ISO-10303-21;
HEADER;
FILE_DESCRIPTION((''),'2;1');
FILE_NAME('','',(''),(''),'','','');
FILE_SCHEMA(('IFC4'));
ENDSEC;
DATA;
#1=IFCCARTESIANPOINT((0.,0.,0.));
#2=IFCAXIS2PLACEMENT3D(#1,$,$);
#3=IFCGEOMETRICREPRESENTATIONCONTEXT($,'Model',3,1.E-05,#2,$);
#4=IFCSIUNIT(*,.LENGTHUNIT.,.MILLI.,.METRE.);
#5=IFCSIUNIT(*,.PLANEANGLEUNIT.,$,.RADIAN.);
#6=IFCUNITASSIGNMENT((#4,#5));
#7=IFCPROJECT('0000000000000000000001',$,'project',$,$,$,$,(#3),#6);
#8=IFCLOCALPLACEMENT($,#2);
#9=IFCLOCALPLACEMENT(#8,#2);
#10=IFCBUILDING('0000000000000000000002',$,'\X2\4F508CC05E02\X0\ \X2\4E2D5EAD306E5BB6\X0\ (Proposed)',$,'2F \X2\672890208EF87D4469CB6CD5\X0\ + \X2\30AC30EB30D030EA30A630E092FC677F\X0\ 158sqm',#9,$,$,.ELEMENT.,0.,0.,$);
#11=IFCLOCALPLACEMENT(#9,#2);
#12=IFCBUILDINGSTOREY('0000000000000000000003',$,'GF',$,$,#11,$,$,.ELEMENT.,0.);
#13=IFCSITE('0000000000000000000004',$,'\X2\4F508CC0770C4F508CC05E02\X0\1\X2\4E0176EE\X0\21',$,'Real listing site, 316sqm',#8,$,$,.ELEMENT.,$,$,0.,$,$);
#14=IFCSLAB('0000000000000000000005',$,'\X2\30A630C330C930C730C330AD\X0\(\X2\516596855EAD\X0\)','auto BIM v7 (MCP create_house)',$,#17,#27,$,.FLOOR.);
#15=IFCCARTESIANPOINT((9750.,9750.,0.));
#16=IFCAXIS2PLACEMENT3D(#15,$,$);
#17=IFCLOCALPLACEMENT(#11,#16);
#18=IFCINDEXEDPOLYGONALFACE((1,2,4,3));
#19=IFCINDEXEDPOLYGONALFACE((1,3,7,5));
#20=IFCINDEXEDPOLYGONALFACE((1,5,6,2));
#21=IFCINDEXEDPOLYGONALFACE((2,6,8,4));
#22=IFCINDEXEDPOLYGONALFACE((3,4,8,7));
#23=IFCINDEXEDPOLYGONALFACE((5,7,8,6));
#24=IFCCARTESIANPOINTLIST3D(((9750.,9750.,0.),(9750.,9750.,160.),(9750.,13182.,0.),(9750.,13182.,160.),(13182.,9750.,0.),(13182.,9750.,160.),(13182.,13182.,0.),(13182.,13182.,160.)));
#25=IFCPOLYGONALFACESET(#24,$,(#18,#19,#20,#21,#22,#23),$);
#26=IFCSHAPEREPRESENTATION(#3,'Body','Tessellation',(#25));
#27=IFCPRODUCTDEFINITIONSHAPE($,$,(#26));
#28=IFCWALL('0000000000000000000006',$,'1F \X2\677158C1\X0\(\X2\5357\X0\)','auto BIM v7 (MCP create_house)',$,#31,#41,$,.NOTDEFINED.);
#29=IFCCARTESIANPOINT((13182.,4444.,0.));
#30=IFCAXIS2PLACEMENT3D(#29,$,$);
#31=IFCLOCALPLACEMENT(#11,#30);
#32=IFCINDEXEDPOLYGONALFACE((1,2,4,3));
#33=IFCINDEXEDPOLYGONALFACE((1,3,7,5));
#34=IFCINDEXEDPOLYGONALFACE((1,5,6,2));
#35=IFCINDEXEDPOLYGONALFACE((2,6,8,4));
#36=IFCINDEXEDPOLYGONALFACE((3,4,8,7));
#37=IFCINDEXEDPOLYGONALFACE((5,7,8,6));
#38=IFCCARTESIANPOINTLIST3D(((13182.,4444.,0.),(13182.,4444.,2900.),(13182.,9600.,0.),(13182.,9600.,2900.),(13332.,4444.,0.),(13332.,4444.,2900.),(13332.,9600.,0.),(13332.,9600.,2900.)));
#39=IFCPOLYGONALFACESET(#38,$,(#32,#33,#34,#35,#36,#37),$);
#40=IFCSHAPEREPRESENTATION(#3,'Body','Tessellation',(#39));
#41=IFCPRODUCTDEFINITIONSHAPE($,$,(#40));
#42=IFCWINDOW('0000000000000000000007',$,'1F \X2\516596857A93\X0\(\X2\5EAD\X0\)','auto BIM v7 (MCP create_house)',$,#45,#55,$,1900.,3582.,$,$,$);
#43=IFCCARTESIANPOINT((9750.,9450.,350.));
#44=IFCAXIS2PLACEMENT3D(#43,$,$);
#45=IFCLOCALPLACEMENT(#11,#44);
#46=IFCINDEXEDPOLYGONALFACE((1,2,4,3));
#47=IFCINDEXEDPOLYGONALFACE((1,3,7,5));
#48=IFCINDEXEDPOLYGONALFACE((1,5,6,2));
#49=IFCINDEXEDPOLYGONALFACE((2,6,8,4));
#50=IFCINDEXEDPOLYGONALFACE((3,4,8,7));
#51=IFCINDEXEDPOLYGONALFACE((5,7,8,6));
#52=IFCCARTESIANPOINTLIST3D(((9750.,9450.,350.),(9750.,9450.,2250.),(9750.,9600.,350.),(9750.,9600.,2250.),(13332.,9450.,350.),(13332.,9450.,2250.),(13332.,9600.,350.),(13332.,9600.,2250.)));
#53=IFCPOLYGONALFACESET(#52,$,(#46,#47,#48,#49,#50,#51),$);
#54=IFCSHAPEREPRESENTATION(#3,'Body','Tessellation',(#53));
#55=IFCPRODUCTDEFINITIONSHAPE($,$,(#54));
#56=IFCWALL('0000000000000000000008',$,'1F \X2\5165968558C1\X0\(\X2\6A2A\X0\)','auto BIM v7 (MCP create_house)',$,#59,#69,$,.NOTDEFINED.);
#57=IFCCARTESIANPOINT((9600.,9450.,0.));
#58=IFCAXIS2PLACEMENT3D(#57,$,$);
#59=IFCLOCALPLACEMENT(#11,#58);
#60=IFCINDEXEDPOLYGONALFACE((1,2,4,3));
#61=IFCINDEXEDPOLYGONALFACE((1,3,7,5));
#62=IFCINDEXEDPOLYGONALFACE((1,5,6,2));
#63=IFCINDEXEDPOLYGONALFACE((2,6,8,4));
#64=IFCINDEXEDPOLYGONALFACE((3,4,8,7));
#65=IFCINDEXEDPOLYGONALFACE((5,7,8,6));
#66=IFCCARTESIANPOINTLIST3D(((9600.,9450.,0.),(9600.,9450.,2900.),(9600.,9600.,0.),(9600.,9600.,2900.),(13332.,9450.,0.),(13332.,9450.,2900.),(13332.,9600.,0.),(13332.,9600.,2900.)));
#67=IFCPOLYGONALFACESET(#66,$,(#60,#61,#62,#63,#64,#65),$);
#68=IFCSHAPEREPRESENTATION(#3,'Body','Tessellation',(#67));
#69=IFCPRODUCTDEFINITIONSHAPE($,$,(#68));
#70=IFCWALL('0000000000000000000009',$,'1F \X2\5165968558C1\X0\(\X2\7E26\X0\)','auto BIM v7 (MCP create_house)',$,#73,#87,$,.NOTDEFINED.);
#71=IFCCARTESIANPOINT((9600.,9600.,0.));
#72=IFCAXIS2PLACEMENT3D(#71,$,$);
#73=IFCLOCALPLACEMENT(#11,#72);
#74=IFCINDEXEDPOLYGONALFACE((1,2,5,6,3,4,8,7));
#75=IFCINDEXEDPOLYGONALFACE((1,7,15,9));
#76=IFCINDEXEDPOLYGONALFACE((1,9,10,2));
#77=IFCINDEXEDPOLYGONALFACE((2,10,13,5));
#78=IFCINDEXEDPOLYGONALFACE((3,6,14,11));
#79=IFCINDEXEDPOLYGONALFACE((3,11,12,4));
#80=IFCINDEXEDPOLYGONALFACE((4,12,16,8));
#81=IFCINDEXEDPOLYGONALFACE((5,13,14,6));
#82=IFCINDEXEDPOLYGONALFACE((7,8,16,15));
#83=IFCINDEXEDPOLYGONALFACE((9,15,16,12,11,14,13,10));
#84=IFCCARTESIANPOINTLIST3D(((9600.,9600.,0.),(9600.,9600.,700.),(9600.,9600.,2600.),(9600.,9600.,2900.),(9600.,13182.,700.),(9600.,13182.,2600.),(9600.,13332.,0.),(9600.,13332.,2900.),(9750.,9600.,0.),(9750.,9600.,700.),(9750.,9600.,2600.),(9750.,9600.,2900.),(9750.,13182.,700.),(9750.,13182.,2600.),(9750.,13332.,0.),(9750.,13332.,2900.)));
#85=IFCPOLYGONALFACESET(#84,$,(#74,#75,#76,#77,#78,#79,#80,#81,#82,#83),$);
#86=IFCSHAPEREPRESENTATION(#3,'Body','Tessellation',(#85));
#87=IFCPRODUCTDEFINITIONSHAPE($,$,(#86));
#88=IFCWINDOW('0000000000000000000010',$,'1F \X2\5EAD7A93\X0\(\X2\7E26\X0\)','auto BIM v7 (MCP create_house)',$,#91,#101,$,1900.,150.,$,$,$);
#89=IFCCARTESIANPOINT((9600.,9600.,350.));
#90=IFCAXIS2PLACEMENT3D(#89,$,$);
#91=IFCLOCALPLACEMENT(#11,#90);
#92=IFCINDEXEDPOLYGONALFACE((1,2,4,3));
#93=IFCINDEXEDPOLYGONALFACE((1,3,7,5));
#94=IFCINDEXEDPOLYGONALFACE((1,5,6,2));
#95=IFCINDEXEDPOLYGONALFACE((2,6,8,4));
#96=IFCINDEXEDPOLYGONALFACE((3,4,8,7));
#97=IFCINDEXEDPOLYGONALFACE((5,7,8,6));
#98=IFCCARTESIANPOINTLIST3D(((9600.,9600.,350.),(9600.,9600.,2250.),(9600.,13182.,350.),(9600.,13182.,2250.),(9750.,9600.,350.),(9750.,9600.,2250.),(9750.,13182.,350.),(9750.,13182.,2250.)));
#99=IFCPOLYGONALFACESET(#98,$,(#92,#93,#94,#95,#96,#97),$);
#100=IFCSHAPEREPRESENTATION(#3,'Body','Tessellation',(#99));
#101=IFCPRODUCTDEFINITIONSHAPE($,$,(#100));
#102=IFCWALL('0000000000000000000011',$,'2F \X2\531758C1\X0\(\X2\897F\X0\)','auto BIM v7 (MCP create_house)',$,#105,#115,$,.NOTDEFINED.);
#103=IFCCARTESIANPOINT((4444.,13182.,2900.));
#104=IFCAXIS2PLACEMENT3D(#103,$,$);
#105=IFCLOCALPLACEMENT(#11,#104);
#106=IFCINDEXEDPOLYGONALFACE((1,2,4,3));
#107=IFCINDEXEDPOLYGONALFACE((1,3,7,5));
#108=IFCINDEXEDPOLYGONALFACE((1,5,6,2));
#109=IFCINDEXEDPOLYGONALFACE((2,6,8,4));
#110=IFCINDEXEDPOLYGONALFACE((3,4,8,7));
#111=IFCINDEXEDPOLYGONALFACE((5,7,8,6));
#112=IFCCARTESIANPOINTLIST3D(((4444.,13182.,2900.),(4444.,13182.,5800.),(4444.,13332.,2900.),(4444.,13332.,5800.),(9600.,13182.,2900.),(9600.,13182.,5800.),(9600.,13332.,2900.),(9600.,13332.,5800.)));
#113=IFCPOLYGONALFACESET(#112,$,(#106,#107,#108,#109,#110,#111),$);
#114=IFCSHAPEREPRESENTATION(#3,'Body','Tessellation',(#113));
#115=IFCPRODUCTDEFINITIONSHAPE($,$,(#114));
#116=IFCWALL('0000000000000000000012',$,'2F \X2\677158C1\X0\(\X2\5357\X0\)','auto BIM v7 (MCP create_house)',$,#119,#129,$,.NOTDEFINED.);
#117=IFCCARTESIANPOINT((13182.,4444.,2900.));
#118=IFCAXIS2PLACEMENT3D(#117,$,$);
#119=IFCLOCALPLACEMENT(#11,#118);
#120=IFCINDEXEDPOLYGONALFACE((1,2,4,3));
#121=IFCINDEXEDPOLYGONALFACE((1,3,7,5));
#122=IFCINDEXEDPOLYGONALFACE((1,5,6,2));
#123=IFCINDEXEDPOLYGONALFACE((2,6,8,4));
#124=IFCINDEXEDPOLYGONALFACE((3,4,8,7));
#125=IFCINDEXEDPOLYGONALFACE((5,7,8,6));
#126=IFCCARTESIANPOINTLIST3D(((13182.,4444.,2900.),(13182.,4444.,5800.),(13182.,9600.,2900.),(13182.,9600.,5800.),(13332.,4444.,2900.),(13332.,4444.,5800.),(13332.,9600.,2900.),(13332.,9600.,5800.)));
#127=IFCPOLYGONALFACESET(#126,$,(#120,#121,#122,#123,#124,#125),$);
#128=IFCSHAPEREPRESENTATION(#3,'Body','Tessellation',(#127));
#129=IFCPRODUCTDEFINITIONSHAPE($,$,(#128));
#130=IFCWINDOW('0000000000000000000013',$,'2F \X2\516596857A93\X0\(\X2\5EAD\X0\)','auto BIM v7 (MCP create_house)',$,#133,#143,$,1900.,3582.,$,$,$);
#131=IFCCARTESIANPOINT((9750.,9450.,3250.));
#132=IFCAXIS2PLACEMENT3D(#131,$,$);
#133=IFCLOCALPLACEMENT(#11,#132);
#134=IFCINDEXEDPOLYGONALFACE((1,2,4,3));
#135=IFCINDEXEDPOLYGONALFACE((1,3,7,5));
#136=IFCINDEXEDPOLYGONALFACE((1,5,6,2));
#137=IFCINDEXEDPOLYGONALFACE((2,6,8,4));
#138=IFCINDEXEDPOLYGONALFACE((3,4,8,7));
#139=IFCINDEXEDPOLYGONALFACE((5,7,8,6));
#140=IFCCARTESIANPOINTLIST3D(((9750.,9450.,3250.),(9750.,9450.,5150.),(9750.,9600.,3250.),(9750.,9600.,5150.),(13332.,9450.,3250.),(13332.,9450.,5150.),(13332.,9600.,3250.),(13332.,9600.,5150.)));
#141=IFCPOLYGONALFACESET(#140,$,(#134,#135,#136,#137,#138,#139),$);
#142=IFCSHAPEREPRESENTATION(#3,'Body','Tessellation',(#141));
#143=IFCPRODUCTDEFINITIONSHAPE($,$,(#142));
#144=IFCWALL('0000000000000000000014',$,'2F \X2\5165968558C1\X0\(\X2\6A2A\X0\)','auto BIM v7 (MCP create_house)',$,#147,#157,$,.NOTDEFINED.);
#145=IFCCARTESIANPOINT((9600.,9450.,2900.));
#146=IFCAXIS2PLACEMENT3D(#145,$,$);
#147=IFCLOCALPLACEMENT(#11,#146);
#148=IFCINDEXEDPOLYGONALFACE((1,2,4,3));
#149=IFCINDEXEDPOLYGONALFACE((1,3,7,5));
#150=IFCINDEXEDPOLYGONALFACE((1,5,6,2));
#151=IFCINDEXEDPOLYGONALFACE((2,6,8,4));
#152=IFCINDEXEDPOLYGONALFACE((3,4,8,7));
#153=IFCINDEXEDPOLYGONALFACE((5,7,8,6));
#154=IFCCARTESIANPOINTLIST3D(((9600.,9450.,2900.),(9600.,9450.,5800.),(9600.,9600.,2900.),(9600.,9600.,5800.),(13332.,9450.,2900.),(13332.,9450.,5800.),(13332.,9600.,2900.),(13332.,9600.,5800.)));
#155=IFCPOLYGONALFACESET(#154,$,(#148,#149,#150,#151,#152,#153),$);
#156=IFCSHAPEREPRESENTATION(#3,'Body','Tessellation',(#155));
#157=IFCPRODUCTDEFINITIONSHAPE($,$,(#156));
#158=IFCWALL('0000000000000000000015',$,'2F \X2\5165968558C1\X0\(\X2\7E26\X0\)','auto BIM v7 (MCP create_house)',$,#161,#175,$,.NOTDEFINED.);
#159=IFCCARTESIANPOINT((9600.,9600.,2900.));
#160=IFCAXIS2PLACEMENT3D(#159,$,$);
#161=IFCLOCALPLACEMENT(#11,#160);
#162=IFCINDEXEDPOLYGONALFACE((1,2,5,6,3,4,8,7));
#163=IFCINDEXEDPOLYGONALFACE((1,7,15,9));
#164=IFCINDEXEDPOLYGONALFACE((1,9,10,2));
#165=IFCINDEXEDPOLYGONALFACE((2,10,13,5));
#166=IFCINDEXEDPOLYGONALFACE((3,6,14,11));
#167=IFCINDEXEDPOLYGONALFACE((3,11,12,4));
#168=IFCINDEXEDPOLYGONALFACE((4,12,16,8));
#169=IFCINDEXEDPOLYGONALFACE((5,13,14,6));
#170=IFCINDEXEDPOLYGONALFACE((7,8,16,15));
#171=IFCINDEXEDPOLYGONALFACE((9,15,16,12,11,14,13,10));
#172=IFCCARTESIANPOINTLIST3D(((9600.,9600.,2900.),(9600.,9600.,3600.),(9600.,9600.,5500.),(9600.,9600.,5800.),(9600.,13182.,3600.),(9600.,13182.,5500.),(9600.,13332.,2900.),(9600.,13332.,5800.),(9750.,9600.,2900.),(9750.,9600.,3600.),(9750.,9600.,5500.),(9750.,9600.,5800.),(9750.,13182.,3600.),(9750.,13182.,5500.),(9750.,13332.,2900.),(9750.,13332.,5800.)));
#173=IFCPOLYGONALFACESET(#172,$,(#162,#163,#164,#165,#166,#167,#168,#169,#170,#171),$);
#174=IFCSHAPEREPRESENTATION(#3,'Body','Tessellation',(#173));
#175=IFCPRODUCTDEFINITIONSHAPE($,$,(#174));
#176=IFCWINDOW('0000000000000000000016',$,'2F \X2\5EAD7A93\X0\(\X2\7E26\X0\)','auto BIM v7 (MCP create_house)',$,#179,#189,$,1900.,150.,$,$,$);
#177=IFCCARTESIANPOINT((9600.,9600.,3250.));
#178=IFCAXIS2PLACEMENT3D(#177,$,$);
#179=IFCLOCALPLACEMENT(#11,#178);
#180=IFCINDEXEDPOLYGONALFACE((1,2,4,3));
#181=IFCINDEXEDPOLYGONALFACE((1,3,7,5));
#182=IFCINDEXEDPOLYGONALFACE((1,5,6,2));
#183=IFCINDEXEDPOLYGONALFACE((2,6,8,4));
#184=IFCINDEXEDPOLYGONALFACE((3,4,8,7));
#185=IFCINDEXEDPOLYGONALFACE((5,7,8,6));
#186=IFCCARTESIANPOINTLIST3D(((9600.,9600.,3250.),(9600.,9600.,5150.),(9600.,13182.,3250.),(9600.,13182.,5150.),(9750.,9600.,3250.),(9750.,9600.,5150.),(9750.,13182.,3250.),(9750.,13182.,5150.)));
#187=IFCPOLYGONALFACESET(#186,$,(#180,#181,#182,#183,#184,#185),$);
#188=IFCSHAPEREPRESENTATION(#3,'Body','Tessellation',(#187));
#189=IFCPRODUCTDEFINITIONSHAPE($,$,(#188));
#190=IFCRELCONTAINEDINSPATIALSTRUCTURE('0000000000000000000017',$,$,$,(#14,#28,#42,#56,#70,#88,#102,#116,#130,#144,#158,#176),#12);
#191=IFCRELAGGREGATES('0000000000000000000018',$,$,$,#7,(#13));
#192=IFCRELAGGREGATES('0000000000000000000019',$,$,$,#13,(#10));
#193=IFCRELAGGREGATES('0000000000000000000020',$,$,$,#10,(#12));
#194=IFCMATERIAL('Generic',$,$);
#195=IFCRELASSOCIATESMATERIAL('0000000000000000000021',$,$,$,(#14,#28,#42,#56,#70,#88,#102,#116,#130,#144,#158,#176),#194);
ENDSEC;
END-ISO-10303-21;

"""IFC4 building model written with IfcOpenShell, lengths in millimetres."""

from ifc_helpers import new_model, si_unit, frame, frame_2d, origin, place, context, project, spatial, rectangle, extrude, material, element, fill, save


model = new_model("IFC4")

# Units and contexts
model_context = context("Model", 3, precision=1e-05, world=origin())
ifc_project = project(units=[si_unit("LENGTHUNIT", "METRE", prefix="MILLI"), si_unit("PLANEANGLEUNIT", "RADIAN")], contexts=[model_context])

# Site, building, storey
site_placement = place(None, origin())
site = spatial("IfcSite", under=ifc_project, at=site_placement, Name="佐賀県佐賀市1丁目21", ObjectType="Real listing site, 316sqm", CompositionType="ELEMENT", RefElevation=0.0)
building_placement = place(site_placement, origin())
building = spatial("IfcBuilding", under=site, at=building_placement, Name="佐賀市 中庭の家 (Proposed)", ObjectType="2F 木造軸組構法 + ガルバリウム鋼板 158sqm", CompositionType="ELEMENT", ElevationOfRefHeight=0.0, ElevationOfTerrain=0.0)
storey_placement = place(building_placement, origin())
storey = spatial("IfcBuildingStorey", under=building, at=storey_placement, Name="GF", CompositionType="ELEMENT", Elevation=0.0)

# Slab
ifc_material = material(Name="Generic")
slab_placement = place(storey_placement, frame((9750.0, 9750.0, 0.0)))
element("IfcSlab", 1, at=slab_placement, inside=storey, material=ifc_material, Name="ウッドデッキ(入隅庭)", Description="auto BIM v7 (MCP create_house)", PredefinedType="FLOOR", context=model_context, shape_type="SweptSolid", body=[
    extrude(rectangle(XDim=3432.0, YDim=3432.0, at=frame_2d((1716.0, 1716.0))), frame((9750.0, 9750.0, 0.0)), (0.0, 0.0, 1.0), 160.0),
])

# Wall, opening, window
wall_1_placement = place(storey_placement, frame((13182.0, 4444.0, 0.0)))
wall_1 = element("IfcWall", 2, at=wall_1_placement, inside=storey, material=ifc_material, Name="1F 東壁(南)", Description="auto BIM v7 (MCP create_house)", PredefinedType="NOTDEFINED", context=model_context, shape_type="SweptSolid", body=[
    extrude(rectangle(XDim=150.0, YDim=5156.0, at=frame_2d((75.0, 2578.0))), frame((13182.0, 4444.0, 0.0)), (0.0, 0.0, 1.0), 2900.0),
])
opening_1_placement = place(storey_placement, frame((9750.0, 9450.0, 350.0)))
opening_1 = element("IfcOpeningElement", 3, at=opening_1_placement, cuts=wall_1, PredefinedType="NOTDEFINED", context=model_context, shape_type="SweptSolid", body=[
    extrude(rectangle(XDim=3582.0, YDim=150.0, at=frame_2d((1791.0, 75.0))), frame((9750.0, 9450.0, 350.0)), (0.0, 0.0, 1.0), 1900.0),
])
window_1_placement = place(storey_placement, frame((9750.0, 9450.0, 350.0)))
window_1 = element("IfcWindow", 4, at=window_1_placement, inside=storey, material=ifc_material, Name="1F 入隅窓(庭)", Description="auto BIM v7 (MCP create_house)", OverallHeight=1900.0, OverallWidth=3582.0, context=model_context, shape_type="SweptSolid", body=[
    extrude(rectangle(XDim=3582.0, YDim=150.0, at=frame_2d((1791.0, 75.0))), frame((9750.0, 9450.0, 350.0)), (0.0, 0.0, 1.0), 1900.0),
])
fill(opening_1, window_1)

# Wall
wall_2_placement = place(storey_placement, frame((9600.0, 9450.0, 0.0)))
element("IfcWall", 5, at=wall_2_placement, inside=storey, material=ifc_material, Name="1F 入隅壁(横)", Description="auto BIM v7 (MCP create_house)", PredefinedType="NOTDEFINED", context=model_context, shape_type="SweptSolid", body=[
    extrude(rectangle(XDim=3732.0, YDim=150.0, at=frame_2d((1866.0, 75.0))), frame((9600.0, 9450.0, 0.0)), (0.0, 0.0, 1.0), 2900.0),
])

# Wall, opening, window
wall_3_placement = place(storey_placement, frame((9600.0, 9600.0, 0.0)))
wall_3 = element("IfcWall", 6, at=wall_3_placement, inside=storey, material=ifc_material, Name="1F 入隅壁(縦)", Description="auto BIM v7 (MCP create_house)", PredefinedType="NOTDEFINED", context=model_context, shape_type="SweptSolid", body=[
    extrude(rectangle(XDim=150.0, YDim=3732.0, at=frame_2d((75.0, 1866.0))), frame((9600.0, 9600.0, 0.0)), (0.0, 0.0, 1.0), 2900.0),
])
opening_2_placement = place(storey_placement, frame((9600.0, 9600.0, 350.0)))
opening_2 = element("IfcOpeningElement", 7, at=opening_2_placement, cuts=wall_3, PredefinedType="NOTDEFINED", context=model_context, shape_type="SweptSolid", body=[
    extrude(rectangle(XDim=150.0, YDim=3582.0, at=frame_2d((75.0, 1791.0))), frame((9600.0, 9600.0, 350.0)), (0.0, 0.0, 1.0), 1900.0),
])
window_2_placement = place(storey_placement, frame((9600.0, 9600.0, 350.0)))
window_2 = element("IfcWindow", 8, at=window_2_placement, inside=storey, material=ifc_material, Name="1F 庭窓(縦)", Description="auto BIM v7 (MCP create_house)", OverallHeight=1900.0, OverallWidth=150.0, context=model_context, shape_type="SweptSolid", body=[
    extrude(rectangle(XDim=150.0, YDim=3582.0, at=frame_2d((75.0, 1791.0))), frame((9600.0, 9600.0, 350.0)), (0.0, 0.0, 1.0), 1900.0),
])
fill(opening_2, window_2)

# Wall
wall_4_placement = place(storey_placement, frame((4444.0, 13182.0, 2900.0)))
element("IfcWall", 9, at=wall_4_placement, inside=storey, material=ifc_material, Name="2F 北壁(西)", Description="auto BIM v7 (MCP create_house)", PredefinedType="NOTDEFINED", context=model_context, shape_type="SweptSolid", body=[
    extrude(rectangle(XDim=5156.0, YDim=150.0, at=frame_2d((2578.0, 75.0))), frame((4444.0, 13182.0, 2900.0)), (0.0, 0.0, 1.0), 2900.0),
])

# Wall, opening, window
wall_5_placement = place(storey_placement, frame((13182.0, 4444.0, 2900.0)))
wall_5 = element("IfcWall", 10, at=wall_5_placement, inside=storey, material=ifc_material, Name="2F 東壁(南)", Description="auto BIM v7 (MCP create_house)", PredefinedType="NOTDEFINED", context=model_context, shape_type="SweptSolid", body=[
    extrude(rectangle(XDim=150.0, YDim=5156.0, at=frame_2d((75.0, 2578.0))), frame((13182.0, 4444.0, 2900.0)), (0.0, 0.0, 1.0), 2900.0),
])
opening_3_placement = place(storey_placement, frame((9750.0, 9450.0, 3250.0)))
opening_3 = element("IfcOpeningElement", 11, at=opening_3_placement, cuts=wall_5, PredefinedType="NOTDEFINED", context=model_context, shape_type="SweptSolid", body=[
    extrude(rectangle(XDim=3582.0, YDim=150.0, at=frame_2d((1791.0, 75.0))), frame((9750.0, 9450.0, 3250.0)), (0.0, 0.0, 1.0), 1900.0),
])
window_3_placement = place(storey_placement, frame((9750.0, 9450.0, 3250.0)))
window_3 = element("IfcWindow", 12, at=window_3_placement, inside=storey, material=ifc_material, Name="2F 入隅窓(庭)", Description="auto BIM v7 (MCP create_house)", OverallHeight=1900.0, OverallWidth=3582.0, context=model_context, shape_type="SweptSolid", body=[
    extrude(rectangle(XDim=3582.0, YDim=150.0, at=frame_2d((1791.0, 75.0))), frame((9750.0, 9450.0, 3250.0)), (0.0, 0.0, 1.0), 1900.0),
])
fill(opening_3, window_3)

# Wall
wall_6_placement = place(storey_placement, frame((9600.0, 9450.0, 2900.0)))
element("IfcWall", 13, at=wall_6_placement, inside=storey, material=ifc_material, Name="2F 入隅壁(横)", Description="auto BIM v7 (MCP create_house)", PredefinedType="NOTDEFINED", context=model_context, shape_type="SweptSolid", body=[
    extrude(rectangle(XDim=3732.0, YDim=150.0, at=frame_2d((1866.0, 75.0))), frame((9600.0, 9450.0, 2900.0)), (0.0, 0.0, 1.0), 2900.0),
])

# Wall, opening, window
wall_7_placement = place(storey_placement, frame((9600.0, 9600.0, 2900.0)))
wall_7 = element("IfcWall", 14, at=wall_7_placement, inside=storey, material=ifc_material, Name="2F 入隅壁(縦)", Description="auto BIM v7 (MCP create_house)", PredefinedType="NOTDEFINED", context=model_context, shape_type="SweptSolid", body=[
    extrude(rectangle(XDim=150.0, YDim=3732.0, at=frame_2d((75.0, 1866.0))), frame((9600.0, 9600.0, 2900.0)), (0.0, 0.0, 1.0), 2900.0),
])
opening_4_placement = place(storey_placement, frame((9600.0, 9600.0, 3250.0)))
opening_4 = element("IfcOpeningElement", 15, at=opening_4_placement, cuts=wall_7, PredefinedType="NOTDEFINED", context=model_context, shape_type="SweptSolid", body=[
    extrude(rectangle(XDim=150.0, YDim=3582.0, at=frame_2d((75.0, 1791.0))), frame((9600.0, 9600.0, 3250.0)), (0.0, 0.0, 1.0), 1900.0),
])
window_4_placement = place(storey_placement, frame((9600.0, 9600.0, 3250.0)))
window_4 = element("IfcWindow", 16, at=window_4_placement, inside=storey, material=ifc_material, Name="2F 庭窓(縦)", Description="auto BIM v7 (MCP create_house)", OverallHeight=1900.0, OverallWidth=150.0, context=model_context, shape_type="SweptSolid", body=[
    extrude(rectangle(XDim=150.0, YDim=3582.0, at=frame_2d((75.0, 1791.0))), frame((9600.0, 9600.0, 3250.0)), (0.0, 0.0, 1.0), 1900.0),
])
fill(opening_4, window_4)

save(model, "model.ifc")
